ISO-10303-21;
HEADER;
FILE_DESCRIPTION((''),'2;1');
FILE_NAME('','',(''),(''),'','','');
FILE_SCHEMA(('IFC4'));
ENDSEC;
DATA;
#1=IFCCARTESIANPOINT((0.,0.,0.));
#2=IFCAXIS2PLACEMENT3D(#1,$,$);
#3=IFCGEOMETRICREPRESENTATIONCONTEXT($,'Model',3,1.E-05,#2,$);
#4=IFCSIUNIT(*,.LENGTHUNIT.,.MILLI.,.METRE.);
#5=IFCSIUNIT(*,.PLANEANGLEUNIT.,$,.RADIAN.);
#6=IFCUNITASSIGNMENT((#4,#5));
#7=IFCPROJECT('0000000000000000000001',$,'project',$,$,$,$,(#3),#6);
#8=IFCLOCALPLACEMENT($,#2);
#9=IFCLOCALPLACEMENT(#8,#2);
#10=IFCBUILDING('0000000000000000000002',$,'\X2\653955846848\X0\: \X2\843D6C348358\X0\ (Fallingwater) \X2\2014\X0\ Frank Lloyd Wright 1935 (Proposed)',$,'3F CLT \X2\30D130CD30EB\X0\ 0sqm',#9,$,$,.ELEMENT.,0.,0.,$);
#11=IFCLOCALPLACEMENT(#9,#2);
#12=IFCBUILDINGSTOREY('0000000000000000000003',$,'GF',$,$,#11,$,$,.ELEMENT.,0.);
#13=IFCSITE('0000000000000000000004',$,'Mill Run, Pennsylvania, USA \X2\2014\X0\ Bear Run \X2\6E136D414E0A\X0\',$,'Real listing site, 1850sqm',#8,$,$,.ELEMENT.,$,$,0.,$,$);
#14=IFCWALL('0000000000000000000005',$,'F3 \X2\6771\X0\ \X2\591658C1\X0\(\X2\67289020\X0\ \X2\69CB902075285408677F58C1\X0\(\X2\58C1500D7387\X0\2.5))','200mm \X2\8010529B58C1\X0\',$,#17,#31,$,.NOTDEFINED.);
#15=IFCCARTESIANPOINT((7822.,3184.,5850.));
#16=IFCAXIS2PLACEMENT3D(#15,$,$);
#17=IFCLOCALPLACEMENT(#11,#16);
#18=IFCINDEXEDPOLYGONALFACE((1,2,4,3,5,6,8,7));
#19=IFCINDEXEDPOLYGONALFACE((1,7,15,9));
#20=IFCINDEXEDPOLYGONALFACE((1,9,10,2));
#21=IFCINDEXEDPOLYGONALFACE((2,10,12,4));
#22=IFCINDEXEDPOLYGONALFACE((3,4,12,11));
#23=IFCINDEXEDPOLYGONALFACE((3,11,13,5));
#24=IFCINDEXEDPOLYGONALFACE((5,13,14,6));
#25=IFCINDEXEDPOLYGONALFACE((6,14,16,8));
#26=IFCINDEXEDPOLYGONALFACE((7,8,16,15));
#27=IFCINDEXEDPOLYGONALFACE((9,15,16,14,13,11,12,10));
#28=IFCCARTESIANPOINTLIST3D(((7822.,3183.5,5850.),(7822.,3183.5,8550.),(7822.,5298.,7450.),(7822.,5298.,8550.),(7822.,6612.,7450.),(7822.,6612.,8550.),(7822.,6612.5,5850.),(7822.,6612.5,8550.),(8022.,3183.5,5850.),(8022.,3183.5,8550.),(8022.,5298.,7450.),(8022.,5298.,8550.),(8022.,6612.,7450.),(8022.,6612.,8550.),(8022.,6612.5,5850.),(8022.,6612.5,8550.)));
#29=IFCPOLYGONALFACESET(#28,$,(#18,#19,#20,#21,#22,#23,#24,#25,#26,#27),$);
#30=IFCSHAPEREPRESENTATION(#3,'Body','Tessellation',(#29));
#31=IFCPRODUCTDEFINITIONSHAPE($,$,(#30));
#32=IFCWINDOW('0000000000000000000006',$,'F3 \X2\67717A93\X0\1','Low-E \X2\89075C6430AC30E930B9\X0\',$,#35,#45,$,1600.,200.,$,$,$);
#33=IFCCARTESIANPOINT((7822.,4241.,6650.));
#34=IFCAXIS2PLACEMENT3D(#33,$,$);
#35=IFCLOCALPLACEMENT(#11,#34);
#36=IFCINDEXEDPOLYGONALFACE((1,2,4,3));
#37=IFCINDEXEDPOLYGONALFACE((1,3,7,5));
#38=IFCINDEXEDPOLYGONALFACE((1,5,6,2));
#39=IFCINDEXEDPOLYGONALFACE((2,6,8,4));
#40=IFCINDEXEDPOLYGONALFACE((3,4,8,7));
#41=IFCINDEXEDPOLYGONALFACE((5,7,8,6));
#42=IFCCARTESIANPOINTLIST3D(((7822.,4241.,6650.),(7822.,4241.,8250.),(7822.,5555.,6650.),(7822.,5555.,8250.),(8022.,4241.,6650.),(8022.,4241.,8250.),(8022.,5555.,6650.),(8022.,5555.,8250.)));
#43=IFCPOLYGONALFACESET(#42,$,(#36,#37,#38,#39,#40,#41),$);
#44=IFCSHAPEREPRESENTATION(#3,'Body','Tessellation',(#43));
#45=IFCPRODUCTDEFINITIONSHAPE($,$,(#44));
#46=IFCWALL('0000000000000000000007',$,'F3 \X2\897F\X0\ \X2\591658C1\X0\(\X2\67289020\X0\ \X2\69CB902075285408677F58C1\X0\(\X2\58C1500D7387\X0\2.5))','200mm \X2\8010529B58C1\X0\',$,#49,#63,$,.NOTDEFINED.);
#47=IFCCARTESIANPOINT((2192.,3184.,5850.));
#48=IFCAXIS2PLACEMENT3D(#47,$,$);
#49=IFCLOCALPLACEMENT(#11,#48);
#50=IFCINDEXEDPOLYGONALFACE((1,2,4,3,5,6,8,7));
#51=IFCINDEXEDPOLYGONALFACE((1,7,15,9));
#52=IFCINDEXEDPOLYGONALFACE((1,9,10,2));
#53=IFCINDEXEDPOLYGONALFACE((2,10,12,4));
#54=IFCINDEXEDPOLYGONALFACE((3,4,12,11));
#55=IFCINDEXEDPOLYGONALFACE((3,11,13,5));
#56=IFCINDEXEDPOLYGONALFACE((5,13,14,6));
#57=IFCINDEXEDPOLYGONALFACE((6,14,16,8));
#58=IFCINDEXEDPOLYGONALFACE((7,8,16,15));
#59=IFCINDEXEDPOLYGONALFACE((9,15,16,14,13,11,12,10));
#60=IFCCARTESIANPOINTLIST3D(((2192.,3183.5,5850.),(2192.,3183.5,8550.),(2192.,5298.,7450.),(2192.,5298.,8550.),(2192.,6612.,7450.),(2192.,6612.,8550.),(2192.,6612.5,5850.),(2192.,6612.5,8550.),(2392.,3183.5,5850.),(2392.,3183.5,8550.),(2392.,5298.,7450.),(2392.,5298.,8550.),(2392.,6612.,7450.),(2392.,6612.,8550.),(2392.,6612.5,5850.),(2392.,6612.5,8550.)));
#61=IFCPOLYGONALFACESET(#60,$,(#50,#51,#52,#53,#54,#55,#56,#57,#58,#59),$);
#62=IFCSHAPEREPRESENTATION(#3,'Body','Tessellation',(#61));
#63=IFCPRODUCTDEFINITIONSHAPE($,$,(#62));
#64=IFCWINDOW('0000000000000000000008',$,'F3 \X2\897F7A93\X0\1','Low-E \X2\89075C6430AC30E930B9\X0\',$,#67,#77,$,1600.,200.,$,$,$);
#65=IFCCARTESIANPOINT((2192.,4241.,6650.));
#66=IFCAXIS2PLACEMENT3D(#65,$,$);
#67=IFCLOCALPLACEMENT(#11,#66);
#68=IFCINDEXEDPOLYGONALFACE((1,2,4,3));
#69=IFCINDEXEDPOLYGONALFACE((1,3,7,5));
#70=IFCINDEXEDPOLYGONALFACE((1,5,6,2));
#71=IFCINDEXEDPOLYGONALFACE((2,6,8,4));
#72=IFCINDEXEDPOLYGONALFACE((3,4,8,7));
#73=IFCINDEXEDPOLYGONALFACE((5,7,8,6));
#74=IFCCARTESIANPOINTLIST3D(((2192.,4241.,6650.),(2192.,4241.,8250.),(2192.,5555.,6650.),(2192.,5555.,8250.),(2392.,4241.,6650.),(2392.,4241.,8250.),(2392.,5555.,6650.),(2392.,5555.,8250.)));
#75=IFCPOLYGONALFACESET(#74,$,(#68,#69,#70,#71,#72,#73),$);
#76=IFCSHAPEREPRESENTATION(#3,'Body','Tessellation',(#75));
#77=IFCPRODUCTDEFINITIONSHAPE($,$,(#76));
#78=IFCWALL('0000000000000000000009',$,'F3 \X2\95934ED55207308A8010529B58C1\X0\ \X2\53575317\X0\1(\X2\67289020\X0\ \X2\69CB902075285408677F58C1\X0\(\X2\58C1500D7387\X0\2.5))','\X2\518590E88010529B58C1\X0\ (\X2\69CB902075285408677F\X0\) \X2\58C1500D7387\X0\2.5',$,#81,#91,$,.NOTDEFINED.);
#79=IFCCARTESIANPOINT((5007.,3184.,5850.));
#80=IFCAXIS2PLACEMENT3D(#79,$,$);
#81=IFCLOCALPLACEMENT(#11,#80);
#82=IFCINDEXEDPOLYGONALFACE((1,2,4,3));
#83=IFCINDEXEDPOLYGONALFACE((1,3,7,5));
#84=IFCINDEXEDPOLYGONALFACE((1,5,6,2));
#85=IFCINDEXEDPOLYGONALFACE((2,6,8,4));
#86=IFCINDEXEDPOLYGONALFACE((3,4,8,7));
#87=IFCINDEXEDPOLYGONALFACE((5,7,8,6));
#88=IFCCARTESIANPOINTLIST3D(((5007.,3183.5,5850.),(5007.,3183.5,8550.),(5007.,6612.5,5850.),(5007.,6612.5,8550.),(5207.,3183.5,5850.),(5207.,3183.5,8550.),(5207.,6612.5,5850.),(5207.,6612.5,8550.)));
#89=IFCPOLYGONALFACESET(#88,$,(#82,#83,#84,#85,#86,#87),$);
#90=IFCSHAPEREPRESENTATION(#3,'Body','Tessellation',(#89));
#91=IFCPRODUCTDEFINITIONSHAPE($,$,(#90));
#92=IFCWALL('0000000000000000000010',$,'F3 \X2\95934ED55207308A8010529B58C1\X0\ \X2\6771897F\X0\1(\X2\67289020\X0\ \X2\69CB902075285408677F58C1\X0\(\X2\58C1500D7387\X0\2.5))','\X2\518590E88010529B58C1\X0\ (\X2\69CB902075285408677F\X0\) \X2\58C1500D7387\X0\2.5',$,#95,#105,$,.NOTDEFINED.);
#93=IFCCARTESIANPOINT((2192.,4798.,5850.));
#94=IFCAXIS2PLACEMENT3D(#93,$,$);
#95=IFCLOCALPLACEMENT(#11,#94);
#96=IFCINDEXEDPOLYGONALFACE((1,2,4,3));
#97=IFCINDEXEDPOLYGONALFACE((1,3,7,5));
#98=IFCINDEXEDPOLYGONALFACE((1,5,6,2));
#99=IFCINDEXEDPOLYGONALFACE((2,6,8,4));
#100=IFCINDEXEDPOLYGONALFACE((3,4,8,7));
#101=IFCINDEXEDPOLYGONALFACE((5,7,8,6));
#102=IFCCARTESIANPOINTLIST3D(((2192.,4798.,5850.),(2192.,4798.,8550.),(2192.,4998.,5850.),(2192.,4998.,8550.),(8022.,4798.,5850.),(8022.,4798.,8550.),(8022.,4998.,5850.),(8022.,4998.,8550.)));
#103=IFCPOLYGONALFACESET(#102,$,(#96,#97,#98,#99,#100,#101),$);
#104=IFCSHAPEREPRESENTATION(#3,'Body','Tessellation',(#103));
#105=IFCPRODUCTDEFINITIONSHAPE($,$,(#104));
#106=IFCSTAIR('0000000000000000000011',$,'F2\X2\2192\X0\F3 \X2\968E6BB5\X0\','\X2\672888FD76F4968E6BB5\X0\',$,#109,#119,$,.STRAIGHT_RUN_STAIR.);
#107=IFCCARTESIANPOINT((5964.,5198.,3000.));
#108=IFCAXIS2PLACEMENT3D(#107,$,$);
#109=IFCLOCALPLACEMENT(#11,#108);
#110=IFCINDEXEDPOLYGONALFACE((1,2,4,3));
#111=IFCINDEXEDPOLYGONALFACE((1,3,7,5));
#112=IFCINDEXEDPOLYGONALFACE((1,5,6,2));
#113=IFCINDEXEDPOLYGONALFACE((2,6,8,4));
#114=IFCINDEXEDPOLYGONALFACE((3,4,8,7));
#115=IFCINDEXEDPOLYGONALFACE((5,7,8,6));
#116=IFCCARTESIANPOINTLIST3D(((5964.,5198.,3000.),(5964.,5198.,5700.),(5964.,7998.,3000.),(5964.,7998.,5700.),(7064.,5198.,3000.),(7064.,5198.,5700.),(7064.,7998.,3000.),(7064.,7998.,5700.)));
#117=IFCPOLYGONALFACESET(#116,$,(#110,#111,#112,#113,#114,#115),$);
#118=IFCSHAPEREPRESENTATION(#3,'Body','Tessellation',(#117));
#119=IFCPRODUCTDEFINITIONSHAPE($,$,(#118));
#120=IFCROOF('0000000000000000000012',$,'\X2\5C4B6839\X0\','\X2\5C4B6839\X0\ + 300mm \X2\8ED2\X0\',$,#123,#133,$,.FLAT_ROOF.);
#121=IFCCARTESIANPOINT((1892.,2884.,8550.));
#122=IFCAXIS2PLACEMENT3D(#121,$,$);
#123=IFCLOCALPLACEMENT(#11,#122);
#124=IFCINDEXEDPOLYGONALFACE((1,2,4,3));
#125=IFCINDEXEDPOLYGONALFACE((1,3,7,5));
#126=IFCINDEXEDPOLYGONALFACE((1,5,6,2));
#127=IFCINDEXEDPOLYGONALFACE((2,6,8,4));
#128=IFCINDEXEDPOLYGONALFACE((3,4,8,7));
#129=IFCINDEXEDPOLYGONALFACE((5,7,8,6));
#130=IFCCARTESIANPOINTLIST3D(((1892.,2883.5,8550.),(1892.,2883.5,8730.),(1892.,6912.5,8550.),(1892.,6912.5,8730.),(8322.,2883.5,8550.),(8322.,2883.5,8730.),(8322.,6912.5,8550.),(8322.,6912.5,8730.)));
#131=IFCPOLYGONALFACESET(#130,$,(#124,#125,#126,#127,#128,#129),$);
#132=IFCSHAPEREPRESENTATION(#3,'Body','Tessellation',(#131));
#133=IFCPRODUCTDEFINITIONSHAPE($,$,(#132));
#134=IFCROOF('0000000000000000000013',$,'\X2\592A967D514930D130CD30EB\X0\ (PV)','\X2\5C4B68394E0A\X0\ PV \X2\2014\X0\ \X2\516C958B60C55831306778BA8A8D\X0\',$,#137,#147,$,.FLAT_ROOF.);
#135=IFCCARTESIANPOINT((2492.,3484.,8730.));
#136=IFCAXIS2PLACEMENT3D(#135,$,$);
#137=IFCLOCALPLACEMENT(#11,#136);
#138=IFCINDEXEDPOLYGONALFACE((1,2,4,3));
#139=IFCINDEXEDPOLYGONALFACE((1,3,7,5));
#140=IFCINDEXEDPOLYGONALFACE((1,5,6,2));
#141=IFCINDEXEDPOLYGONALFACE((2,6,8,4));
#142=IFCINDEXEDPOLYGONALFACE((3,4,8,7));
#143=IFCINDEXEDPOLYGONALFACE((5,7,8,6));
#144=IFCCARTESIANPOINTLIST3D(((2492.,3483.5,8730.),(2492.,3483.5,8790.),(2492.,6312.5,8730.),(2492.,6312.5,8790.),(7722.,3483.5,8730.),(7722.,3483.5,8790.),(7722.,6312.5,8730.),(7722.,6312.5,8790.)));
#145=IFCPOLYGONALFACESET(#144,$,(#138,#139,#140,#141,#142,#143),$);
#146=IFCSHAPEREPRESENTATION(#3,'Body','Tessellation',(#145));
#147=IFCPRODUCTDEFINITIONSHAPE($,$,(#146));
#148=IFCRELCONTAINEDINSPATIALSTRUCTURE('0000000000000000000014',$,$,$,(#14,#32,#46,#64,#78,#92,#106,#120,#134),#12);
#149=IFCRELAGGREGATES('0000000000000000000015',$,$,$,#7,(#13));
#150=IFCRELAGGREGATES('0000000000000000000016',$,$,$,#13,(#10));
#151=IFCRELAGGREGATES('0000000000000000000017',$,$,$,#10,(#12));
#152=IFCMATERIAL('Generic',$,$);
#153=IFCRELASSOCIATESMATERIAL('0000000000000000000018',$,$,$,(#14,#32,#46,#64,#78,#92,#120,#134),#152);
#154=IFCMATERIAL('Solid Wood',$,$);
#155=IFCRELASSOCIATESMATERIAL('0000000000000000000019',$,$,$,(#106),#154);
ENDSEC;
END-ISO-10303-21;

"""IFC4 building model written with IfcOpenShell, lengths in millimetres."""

from ifc_helpers import new_model, si_unit, frame, frame_2d, origin, place, context, project, spatial, rectangle, extrude, material, element, fill, save


model = new_model("IFC4")

# Units and contexts
model_context = context("Model", 3, precision=1e-05, world=origin())
ifc_project = project(units=[si_unit("LENGTHUNIT", "METRE", prefix="MILLI"), si_unit("PLANEANGLEUNIT", "RADIAN")], contexts=[model_context])

# Site, building, storey
site_placement = place(None, origin())
site = spatial("IfcSite", under=ifc_project, at=site_placement, Name="Mill Run, Pennsylvania, USA — Bear Run 渓流上", ObjectType="Real listing site, 1850sqm", CompositionType="ELEMENT", RefElevation=0.0)
building_placement = place(site_placement, origin())
building = spatial("IfcBuilding", under=site, at=building_placement, Name="改善案: 落水荘 (Fallingwater) — Frank Lloyd Wright 1935 (Proposed)", ObjectType="3F CLT パネル 0sqm", CompositionType="ELEMENT", ElevationOfRefHeight=0.0, ElevationOfTerrain=0.0)
storey_placement = place(building_placement, origin())
storey = spatial("IfcBuildingStorey", under=building, at=storey_placement, Name="GF", CompositionType="ELEMENT", Elevation=0.0)

# Shared definitions
ifc_material_1 = material(Name="Generic")

# Walls, openings, windows
wall_1_placement = place(storey_placement, frame((7822.0, 3184.0, 5850.0)))
wall_1 = element("IfcWall", 1, at=wall_1_placement, inside=storey, material=ifc_material_1, Name="F3 東 外壁(木造 構造用合板壁(壁倍率2.5))", Description="200mm 耐力壁", PredefinedType="NOTDEFINED", context=model_context, shape_type="SweptSolid", body=[
    extrude(rectangle(XDim=200.0, YDim=3429.0, at=frame_2d((100.0, 1714.0))), frame((7822.0, 3184.0, 5850.0)), (0.0, 0.0, 1.0), 2700.0),
])
opening_1_placement = place(storey_placement, frame((7822.0, 4241.0, 6650.0)))
opening_1 = element("IfcOpeningElement", 2, at=opening_1_placement, cuts=wall_1, PredefinedType="NOTDEFINED", context=model_context, shape_type="SweptSolid", body=[
    extrude(rectangle(XDim=200.0, YDim=1314.0, at=frame_2d((100.0, 657.0))), frame((7822.0, 4241.0, 6650.0)), (0.0, 0.0, 1.0), 1600.0),
])
window_1_placement = place(storey_placement, frame((7822.0, 4241.0, 6650.0)))
window_1 = element("IfcWindow", 3, at=window_1_placement, inside=storey, material=ifc_material_1, Name="F3 東窓1", Description="Low-E 複層ガラス", OverallHeight=1600.0, OverallWidth=200.0, context=model_context, shape_type="SweptSolid", body=[
    extrude(rectangle(XDim=200.0, YDim=1314.0, at=frame_2d((100.0, 657.0))), frame((7822.0, 4241.0, 6650.0)), (0.0, 0.0, 1.0), 1600.0),
])
fill(opening_1, window_1)
wall_2_placement = place(storey_placement, frame((2192.0, 3184.0, 5850.0)))
wall_2 = element("IfcWall", 4, at=wall_2_placement, inside=storey, material=ifc_material_1, Name="F3 西 外壁(木造 構造用合板壁(壁倍率2.5))", Description="200mm 耐力壁", PredefinedType="NOTDEFINED", context=model_context, shape_type="SweptSolid", body=[
    extrude(rectangle(XDim=200.0, YDim=3429.0, at=frame_2d((100.0, 1714.0))), frame((2192.0, 3184.0, 5850.0)), (0.0, 0.0, 1.0), 2700.0),
])
opening_2_placement = place(storey_placement, frame((2192.0, 4241.0, 6650.0)))
opening_2 = element("IfcOpeningElement", 5, at=opening_2_placement, cuts=wall_2, PredefinedType="NOTDEFINED", context=model_context, shape_type="SweptSolid", body=[
    extrude(rectangle(XDim=200.0, YDim=1314.0, at=frame_2d((100.0, 657.0))), frame((2192.0, 4241.0, 6650.0)), (0.0, 0.0, 1.0), 1600.0),
])
window_2_placement = place(storey_placement, frame((2192.0, 4241.0, 6650.0)))
window_2 = element("IfcWindow", 6, at=window_2_placement, inside=storey, material=ifc_material_1, Name="F3 西窓1", Description="Low-E 複層ガラス", OverallHeight=1600.0, OverallWidth=200.0, context=model_context, shape_type="SweptSolid", body=[
    extrude(rectangle(XDim=200.0, YDim=1314.0, at=frame_2d((100.0, 657.0))), frame((2192.0, 4241.0, 6650.0)), (0.0, 0.0, 1.0), 1600.0),
])
fill(opening_2, window_2)

# Walls
wall_3_placement = place(storey_placement, frame((5007.0, 3184.0, 5850.0)))
element("IfcWall", 7, at=wall_3_placement, inside=storey, material=ifc_material_1, Name="F3 間仕切り耐力壁 南北1(木造 構造用合板壁(壁倍率2.5))", Description="内部耐力壁 (構造用合板) 壁倍率2.5", PredefinedType="NOTDEFINED", context=model_context, shape_type="SweptSolid", body=[
    extrude(rectangle(XDim=200.0, YDim=3429.0, at=frame_2d((100.0, 1714.0))), frame((5007.0, 3184.0, 5850.0)), (0.0, 0.0, 1.0), 2700.0),
])
wall_4_placement = place(storey_placement, frame((2192.0, 4798.0, 5850.0)))
element("IfcWall", 8, at=wall_4_placement, inside=storey, material=ifc_material_1, Name="F3 間仕切り耐力壁 東西1(木造 構造用合板壁(壁倍率2.5))", Description="内部耐力壁 (構造用合板) 壁倍率2.5", PredefinedType="NOTDEFINED", context=model_context, shape_type="SweptSolid", body=[
    extrude(rectangle(XDim=5830.0, YDim=200.0, at=frame_2d((2915.0, 100.0))), frame((2192.0, 4798.0, 5850.0)), (0.0, 0.0, 1.0), 2700.0),
])

# Stair
ifc_material_2 = material(Name="Solid Wood")
stair_placement = place(storey_placement, frame((5964.0, 5198.0, 3000.0)))
element("IfcStair", 9, at=stair_placement, inside=storey, material=ifc_material_2, Name="F2→F3 階段", Description="木製直階段", PredefinedType="STRAIGHT_RUN_STAIR", context=model_context, shape_type="SweptSolid", body=[
    extrude(rectangle(XDim=1100.0, YDim=2800.0, at=frame_2d((550.0, 1400.0))), frame((5964.0, 5198.0, 3000.0)), (0.0, 0.0, 1.0), 2700.0),
])

# Roofs
roof_1_placement = place(storey_placement, frame((1892.0, 2884.0, 8550.0)))
element("IfcRoof", 10, at=roof_1_placement, inside=storey, material=ifc_material_1, Name="屋根", Description="屋根 + 300mm 軒", PredefinedType="FLAT_ROOF", context=model_context, shape_type="SweptSolid", body=[
    extrude(rectangle(XDim=6430.0, YDim=4029.0, at=frame_2d((3215.0, 2014.0))), frame((1892.0, 2884.0, 8550.0)), (0.0, 0.0, 1.0), 180.0),
])
roof_2_placement = place(storey_placement, frame((2492.0, 3484.0, 8730.0)))
element("IfcRoof", 11, at=roof_2_placement, inside=storey, material=ifc_material_1, Name="太陽光パネル (PV)", Description="屋根上 PV — 公開情報で確認", PredefinedType="FLAT_ROOF", context=model_context, shape_type="SweptSolid", body=[
    extrude(rectangle(XDim=5230.0, YDim=2829.0, at=frame_2d((2615.0, 1414.0))), frame((2492.0, 3484.0, 8730.0)), (0.0, 0.0, 1.0), 60.0),
])

save(model, "model.ifc")
